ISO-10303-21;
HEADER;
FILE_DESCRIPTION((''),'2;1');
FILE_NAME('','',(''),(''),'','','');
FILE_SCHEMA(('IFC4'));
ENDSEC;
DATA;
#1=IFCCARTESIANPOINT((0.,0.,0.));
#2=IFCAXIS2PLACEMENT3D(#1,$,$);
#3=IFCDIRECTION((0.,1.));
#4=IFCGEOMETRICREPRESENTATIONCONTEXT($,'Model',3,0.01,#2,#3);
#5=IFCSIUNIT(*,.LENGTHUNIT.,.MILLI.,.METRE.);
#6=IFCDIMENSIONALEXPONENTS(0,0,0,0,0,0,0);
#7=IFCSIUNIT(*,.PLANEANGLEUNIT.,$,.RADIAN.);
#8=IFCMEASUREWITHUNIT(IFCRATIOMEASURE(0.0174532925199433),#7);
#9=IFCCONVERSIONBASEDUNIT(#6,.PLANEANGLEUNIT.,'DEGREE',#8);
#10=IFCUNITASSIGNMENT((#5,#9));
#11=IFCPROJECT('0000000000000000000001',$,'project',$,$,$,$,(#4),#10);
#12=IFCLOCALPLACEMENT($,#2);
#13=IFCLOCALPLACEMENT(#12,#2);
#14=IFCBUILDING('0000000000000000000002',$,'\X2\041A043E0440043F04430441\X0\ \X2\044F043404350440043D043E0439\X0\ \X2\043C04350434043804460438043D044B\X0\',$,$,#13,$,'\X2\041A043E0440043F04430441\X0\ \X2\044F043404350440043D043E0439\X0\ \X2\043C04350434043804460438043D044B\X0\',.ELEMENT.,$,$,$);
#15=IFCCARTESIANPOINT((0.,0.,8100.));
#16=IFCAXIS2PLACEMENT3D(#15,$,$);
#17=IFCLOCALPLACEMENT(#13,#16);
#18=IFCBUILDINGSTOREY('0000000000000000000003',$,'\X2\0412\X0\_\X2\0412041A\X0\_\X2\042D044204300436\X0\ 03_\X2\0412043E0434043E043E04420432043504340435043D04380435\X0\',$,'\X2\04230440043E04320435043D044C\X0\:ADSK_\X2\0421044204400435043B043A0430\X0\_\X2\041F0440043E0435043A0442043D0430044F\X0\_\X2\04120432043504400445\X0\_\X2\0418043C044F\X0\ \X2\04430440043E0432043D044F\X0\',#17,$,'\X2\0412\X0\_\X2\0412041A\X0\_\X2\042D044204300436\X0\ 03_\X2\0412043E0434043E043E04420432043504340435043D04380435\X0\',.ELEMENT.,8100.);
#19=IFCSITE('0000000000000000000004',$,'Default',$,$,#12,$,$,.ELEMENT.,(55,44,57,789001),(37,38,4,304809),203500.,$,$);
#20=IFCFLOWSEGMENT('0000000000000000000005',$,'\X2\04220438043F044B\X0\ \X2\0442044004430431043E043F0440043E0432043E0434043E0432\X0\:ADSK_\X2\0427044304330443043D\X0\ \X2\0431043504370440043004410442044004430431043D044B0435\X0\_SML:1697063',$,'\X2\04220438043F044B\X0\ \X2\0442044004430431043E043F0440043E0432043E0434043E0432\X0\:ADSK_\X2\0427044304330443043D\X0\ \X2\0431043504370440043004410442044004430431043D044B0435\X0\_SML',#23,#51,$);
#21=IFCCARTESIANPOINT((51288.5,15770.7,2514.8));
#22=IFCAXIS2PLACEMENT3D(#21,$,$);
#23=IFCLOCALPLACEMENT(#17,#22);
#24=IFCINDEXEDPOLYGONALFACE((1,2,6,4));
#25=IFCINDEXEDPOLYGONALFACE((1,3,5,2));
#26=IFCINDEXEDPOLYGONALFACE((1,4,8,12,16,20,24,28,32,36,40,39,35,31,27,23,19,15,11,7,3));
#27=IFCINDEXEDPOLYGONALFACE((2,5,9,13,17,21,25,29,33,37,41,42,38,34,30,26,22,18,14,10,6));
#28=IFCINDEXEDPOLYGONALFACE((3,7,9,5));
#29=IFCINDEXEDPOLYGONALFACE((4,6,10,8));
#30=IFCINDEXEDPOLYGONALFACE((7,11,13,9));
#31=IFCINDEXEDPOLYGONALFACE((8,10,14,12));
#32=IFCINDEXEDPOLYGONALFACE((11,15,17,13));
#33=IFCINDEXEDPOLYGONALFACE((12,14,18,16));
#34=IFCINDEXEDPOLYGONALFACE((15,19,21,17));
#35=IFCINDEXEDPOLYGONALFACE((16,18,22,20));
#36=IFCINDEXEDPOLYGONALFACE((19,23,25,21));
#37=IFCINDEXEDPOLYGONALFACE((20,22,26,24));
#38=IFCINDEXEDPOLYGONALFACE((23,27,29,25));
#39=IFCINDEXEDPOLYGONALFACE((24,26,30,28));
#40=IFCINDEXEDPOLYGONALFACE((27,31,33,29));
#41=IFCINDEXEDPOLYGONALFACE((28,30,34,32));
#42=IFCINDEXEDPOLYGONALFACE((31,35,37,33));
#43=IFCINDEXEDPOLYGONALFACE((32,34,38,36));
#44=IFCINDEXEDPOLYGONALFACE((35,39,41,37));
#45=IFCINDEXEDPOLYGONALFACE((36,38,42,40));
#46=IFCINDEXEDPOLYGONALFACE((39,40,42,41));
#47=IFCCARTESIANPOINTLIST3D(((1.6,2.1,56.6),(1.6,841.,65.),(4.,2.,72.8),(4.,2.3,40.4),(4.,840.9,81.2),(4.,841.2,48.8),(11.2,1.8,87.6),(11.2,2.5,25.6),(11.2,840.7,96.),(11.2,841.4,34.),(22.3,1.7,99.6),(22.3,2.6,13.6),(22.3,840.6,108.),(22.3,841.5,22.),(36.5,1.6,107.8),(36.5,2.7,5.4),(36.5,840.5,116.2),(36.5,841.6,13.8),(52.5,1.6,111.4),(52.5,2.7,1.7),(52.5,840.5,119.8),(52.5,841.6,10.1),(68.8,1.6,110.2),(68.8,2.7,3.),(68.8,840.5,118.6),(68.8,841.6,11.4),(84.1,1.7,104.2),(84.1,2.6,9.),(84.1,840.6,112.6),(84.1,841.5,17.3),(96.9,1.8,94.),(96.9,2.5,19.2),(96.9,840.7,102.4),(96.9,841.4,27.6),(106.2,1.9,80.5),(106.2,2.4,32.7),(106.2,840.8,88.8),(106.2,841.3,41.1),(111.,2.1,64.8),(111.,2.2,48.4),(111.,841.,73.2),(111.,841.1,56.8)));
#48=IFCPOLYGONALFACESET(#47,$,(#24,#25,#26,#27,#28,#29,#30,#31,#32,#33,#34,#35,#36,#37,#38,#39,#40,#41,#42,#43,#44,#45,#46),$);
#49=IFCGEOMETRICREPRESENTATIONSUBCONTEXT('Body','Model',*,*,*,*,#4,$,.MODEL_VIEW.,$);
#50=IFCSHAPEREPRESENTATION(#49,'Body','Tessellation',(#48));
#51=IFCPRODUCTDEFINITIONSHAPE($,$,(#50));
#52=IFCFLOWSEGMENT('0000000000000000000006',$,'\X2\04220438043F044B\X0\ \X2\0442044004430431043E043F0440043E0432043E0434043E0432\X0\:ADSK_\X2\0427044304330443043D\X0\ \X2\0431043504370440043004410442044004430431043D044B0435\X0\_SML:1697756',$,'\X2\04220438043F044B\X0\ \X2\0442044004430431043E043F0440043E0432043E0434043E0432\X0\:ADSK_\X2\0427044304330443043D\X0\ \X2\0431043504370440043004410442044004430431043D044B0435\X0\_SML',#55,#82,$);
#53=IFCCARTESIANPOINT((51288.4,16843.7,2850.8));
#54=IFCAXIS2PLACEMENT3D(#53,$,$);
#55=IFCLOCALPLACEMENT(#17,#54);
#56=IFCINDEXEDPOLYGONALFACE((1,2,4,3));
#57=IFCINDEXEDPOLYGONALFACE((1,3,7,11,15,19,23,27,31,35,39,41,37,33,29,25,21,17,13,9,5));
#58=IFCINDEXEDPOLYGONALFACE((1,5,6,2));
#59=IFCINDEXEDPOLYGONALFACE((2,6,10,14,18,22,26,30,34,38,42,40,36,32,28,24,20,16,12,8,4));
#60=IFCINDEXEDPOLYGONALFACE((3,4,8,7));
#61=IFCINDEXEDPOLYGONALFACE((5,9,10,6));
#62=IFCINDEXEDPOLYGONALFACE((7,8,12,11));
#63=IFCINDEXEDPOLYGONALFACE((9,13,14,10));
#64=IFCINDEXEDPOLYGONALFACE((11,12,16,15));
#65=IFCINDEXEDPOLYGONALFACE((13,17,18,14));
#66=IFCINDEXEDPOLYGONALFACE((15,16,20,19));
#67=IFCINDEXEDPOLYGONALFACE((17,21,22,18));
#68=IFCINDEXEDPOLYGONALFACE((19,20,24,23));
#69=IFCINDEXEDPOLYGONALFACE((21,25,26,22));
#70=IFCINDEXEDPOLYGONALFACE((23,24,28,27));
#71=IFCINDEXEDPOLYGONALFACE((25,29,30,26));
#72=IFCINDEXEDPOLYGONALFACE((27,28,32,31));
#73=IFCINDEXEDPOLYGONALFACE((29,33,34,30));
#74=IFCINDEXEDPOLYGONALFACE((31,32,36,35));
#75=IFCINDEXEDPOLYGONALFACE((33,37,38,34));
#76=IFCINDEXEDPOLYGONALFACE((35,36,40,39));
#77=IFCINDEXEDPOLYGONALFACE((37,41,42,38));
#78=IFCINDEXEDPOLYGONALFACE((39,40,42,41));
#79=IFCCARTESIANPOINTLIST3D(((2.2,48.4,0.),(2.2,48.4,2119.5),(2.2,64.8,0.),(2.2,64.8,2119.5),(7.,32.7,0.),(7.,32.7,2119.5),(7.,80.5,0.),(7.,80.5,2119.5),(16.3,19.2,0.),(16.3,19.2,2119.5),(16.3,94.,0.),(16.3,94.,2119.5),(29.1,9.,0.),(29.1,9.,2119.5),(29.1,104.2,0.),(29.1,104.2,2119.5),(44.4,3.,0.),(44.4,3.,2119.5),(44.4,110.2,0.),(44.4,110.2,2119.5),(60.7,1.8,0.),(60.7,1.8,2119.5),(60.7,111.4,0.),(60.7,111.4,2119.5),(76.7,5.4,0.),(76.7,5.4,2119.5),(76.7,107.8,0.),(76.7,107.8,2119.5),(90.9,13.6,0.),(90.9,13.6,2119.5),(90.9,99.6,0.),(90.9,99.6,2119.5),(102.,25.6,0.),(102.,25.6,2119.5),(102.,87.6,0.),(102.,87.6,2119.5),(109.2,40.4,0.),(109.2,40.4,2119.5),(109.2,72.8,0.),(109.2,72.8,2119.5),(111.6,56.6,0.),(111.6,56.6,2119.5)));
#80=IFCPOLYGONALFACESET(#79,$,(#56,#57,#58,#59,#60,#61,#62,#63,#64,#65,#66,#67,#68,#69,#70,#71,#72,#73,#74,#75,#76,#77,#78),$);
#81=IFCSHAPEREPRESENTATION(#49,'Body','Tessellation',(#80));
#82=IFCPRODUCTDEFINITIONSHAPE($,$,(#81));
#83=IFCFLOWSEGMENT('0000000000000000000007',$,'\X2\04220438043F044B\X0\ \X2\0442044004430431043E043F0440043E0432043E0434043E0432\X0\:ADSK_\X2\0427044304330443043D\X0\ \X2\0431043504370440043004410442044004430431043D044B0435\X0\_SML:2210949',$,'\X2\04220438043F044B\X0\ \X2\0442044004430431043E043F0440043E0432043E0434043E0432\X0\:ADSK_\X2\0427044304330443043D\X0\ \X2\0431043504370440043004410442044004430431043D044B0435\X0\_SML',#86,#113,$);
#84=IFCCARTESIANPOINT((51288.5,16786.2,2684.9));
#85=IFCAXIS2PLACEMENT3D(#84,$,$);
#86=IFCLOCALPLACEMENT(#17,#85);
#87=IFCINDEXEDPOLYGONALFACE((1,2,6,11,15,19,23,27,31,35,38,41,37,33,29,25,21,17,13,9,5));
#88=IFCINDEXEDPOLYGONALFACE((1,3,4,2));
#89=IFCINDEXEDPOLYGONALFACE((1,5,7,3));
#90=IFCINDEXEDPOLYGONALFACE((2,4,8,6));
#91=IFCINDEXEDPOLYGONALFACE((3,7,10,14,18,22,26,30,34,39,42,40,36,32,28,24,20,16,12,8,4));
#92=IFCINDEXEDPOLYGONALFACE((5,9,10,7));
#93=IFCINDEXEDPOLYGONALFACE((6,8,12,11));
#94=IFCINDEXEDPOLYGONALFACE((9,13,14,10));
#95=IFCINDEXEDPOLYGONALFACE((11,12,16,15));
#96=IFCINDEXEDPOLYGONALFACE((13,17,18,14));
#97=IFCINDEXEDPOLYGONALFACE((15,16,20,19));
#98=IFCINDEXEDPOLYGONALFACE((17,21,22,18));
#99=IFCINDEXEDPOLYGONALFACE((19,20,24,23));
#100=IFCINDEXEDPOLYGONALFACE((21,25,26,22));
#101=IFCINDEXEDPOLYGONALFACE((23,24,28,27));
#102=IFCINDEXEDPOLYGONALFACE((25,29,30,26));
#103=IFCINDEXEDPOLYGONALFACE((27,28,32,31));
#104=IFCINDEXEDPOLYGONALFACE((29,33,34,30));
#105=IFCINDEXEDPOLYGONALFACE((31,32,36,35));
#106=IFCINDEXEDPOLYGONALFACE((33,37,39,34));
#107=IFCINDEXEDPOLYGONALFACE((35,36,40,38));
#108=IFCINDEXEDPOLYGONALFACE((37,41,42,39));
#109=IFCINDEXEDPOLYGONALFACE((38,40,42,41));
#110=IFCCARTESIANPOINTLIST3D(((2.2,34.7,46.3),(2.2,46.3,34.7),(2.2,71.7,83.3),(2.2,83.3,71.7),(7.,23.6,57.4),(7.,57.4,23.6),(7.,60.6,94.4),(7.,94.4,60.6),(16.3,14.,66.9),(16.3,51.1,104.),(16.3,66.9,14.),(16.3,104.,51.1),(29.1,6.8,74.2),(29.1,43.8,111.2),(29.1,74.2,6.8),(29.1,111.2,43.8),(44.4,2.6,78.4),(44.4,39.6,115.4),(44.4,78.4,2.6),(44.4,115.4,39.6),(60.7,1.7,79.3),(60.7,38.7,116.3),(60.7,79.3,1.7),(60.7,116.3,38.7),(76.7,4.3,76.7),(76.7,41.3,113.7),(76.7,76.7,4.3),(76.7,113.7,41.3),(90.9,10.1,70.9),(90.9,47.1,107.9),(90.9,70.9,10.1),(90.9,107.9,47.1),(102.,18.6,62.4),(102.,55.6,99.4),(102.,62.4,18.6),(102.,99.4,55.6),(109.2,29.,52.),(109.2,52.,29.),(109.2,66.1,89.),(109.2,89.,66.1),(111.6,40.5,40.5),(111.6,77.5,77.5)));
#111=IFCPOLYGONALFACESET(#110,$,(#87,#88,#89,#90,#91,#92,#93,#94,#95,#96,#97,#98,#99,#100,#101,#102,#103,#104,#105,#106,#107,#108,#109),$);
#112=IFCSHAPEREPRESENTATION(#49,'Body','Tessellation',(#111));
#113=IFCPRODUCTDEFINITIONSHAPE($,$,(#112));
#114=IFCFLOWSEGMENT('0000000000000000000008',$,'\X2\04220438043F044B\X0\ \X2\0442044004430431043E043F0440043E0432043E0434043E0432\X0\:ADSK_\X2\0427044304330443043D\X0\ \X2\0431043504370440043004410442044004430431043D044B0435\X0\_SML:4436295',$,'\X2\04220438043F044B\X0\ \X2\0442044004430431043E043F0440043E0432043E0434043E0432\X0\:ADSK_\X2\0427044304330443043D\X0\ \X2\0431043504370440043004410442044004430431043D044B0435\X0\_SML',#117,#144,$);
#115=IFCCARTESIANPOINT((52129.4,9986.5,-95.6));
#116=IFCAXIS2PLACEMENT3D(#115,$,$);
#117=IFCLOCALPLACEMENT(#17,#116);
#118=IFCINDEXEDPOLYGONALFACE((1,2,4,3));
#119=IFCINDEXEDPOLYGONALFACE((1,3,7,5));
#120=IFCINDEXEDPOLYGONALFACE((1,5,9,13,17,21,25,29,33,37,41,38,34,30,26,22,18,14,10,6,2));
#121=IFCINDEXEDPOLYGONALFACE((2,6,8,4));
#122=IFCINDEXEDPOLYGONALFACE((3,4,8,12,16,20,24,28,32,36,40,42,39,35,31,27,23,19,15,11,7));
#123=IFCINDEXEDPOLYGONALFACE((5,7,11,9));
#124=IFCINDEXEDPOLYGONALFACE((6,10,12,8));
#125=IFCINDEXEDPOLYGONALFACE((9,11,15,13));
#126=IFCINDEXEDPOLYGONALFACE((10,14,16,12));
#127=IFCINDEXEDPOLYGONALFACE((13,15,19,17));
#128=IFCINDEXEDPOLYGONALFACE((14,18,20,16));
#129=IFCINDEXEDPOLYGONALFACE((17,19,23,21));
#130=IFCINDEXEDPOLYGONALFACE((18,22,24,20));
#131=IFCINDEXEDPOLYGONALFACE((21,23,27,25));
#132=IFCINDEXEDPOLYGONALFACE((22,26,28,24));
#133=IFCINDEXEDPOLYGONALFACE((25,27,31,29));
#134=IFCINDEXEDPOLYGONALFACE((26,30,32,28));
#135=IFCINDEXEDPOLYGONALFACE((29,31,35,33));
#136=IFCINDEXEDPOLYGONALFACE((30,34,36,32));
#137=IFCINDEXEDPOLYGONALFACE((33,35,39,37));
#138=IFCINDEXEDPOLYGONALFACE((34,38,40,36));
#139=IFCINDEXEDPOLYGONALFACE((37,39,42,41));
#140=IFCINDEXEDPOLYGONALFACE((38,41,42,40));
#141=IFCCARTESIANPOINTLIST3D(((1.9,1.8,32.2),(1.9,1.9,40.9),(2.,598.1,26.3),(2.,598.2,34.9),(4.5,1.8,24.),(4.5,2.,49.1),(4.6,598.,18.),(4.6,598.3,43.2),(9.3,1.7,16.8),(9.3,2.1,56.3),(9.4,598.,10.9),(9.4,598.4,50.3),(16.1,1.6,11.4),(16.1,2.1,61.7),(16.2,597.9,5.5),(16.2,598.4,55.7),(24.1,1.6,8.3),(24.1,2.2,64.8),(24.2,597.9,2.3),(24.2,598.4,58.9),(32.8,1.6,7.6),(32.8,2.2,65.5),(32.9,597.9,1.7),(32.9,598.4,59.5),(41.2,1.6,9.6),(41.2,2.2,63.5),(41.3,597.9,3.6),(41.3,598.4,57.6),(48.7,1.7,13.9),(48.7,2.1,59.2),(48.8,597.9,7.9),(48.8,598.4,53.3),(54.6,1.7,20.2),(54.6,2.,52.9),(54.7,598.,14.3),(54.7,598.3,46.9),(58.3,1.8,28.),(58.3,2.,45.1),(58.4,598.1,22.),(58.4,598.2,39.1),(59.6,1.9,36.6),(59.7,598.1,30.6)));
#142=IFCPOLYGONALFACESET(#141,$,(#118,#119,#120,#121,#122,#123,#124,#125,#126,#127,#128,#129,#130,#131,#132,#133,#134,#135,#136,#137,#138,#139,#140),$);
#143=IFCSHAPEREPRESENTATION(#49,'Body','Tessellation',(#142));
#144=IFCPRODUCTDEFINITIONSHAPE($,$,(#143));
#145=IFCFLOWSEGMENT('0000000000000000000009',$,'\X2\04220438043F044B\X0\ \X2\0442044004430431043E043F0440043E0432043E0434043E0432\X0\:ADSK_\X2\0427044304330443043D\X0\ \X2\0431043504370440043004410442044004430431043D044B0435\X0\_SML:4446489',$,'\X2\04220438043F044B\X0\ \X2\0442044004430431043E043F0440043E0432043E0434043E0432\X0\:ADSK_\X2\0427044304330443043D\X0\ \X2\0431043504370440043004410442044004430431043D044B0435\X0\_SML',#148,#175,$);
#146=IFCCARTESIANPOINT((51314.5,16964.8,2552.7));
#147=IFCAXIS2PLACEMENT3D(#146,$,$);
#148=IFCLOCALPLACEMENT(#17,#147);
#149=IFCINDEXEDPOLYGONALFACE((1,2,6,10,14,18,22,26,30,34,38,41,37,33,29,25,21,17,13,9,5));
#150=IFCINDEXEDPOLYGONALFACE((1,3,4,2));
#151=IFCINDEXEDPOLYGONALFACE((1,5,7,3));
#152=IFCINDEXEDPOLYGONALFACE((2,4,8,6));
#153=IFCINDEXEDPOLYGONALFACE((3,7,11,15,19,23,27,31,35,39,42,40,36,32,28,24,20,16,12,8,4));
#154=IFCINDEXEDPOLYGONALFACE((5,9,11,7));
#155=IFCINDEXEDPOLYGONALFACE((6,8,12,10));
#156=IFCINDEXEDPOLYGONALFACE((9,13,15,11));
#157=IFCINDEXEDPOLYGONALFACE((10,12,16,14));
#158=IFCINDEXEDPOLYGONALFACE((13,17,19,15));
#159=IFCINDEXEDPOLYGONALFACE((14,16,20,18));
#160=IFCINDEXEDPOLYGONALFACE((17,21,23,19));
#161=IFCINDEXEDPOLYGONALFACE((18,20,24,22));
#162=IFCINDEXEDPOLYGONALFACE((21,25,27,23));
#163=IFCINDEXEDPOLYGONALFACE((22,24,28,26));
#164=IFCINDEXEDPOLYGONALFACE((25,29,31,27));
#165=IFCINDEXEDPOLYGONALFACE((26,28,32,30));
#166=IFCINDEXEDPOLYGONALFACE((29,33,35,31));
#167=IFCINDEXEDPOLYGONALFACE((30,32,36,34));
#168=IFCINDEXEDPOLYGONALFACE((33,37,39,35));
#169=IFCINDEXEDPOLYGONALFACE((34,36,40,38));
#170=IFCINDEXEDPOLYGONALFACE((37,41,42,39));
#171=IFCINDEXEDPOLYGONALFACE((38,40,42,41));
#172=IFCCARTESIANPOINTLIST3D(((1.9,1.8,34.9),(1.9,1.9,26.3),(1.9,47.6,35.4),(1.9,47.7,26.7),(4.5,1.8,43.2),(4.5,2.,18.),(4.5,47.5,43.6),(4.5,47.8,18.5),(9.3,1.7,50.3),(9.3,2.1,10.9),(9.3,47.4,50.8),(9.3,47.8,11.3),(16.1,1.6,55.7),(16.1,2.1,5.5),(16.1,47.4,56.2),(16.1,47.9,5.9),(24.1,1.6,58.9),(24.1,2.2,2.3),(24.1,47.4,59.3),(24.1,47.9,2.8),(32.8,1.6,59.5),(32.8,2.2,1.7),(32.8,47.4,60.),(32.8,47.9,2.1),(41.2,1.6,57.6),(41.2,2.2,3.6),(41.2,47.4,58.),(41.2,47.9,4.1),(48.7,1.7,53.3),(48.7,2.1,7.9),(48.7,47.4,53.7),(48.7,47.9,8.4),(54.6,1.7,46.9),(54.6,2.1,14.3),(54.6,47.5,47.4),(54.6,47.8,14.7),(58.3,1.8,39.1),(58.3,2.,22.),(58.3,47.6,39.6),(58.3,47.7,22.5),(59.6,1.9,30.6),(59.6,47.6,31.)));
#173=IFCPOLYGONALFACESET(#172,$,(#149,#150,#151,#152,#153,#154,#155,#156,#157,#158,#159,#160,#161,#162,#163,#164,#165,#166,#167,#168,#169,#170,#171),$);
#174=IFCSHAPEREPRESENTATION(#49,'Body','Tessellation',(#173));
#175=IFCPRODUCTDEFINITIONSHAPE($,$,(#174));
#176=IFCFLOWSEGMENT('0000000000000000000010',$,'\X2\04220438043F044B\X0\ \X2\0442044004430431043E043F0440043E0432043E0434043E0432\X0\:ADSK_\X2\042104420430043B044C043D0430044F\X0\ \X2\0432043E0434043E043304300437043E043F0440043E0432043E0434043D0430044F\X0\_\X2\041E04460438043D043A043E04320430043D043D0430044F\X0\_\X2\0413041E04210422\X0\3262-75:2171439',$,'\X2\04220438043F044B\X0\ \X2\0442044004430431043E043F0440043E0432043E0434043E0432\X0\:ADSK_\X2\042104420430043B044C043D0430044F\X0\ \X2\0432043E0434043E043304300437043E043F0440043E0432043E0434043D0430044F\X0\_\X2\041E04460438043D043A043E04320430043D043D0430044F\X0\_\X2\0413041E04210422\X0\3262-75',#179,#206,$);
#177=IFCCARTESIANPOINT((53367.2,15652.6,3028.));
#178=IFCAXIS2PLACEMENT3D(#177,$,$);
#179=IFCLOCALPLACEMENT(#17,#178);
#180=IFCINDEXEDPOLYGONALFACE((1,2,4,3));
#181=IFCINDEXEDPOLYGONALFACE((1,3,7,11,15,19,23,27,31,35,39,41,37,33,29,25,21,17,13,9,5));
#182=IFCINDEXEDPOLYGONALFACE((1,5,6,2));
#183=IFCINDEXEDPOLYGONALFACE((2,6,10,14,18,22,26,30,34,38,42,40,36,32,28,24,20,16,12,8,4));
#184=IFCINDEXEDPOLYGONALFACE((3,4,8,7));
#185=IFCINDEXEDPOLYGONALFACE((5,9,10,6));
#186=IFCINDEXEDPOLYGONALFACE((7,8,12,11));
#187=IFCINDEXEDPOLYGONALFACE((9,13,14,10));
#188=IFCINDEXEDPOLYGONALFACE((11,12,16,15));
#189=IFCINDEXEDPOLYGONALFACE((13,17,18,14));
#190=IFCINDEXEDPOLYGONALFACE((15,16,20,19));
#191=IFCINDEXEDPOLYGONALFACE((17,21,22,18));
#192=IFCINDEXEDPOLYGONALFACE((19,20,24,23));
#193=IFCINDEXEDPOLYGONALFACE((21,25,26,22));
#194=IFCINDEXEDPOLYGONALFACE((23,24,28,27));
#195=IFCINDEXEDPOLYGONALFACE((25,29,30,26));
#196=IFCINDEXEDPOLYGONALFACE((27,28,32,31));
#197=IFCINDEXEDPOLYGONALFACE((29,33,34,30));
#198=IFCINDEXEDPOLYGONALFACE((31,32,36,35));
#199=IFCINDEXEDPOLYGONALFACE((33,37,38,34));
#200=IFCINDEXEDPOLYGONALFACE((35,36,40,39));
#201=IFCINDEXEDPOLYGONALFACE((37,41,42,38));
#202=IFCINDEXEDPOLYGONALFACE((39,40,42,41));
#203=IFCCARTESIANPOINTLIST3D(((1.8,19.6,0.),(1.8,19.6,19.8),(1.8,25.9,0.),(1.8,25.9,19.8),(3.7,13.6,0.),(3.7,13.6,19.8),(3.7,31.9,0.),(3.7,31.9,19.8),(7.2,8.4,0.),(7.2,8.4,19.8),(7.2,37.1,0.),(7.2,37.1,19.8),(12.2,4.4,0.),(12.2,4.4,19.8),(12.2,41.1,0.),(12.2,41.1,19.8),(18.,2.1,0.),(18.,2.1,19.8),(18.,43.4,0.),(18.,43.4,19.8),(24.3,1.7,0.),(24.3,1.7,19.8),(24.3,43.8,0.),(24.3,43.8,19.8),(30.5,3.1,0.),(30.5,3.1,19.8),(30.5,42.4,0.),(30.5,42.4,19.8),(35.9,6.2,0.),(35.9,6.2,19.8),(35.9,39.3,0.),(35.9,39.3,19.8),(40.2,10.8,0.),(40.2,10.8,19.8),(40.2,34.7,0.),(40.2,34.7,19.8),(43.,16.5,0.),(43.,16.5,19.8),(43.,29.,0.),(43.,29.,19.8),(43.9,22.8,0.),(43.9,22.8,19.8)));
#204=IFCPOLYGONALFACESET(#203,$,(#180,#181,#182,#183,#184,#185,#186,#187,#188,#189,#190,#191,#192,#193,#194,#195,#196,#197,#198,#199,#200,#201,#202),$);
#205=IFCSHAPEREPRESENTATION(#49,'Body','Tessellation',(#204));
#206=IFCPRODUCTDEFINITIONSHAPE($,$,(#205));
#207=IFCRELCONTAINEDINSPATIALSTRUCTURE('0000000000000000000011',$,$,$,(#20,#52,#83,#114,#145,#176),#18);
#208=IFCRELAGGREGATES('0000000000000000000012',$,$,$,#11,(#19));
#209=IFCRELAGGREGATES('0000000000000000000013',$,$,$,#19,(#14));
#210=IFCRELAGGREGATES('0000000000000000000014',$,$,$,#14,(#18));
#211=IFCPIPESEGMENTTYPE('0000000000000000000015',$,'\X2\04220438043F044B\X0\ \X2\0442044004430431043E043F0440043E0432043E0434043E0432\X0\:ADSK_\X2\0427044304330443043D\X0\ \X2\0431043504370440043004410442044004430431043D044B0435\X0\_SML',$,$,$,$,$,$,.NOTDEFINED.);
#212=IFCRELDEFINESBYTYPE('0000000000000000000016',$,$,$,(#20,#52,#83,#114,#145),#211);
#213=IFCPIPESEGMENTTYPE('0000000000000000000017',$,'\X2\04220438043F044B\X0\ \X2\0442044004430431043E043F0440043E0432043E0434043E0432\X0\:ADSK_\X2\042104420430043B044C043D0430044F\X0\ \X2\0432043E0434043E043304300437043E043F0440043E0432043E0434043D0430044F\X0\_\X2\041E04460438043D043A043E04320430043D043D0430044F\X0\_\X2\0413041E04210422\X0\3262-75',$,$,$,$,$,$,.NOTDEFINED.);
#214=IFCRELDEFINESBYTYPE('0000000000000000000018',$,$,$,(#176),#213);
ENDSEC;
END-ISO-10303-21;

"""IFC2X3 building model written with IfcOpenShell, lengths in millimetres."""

from ifc_helpers import new_model, entity, si_unit, converted_unit, direction, frame, origin, origin_2d_with_axis, place, context, subcontext, project, spatial, circle, extrude, type_object, element, save


model = new_model("IFC2X3")

# Units and contexts
model_context = context("Model", 3, precision=0.01, world=origin(), true_north=direction((0.0, 1.0)))
body_context = subcontext(model_context, "Body", "Model", "MODEL_VIEW")
ifc_project = project(units=[si_unit("LENGTHUNIT", "METRE", prefix="MILLI"), converted_unit("PLANEANGLEUNIT", "DEGREE", entity("IfcRatioMeasure", 0.0174532925199433), si_unit("PLANEANGLEUNIT", "RADIAN"), dimensions=[0, 0, 0, 0, 0, 0, 0])], contexts=[model_context])

# Site, building, storey
site_placement = place(None, origin())
site = spatial("IfcSite", under=ifc_project, at=site_placement, Name="Default", CompositionType="ELEMENT", RefLatitude=(55, 44, 57, 789001), RefLongitude=(37, 38, 4, 304809), RefElevation=203500.0)
building_placement = place(site_placement, origin())
building = spatial("IfcBuilding", under=site, at=building_placement, Name="Корпус ядерной медицины", LongName="Корпус ядерной медицины", CompositionType="ELEMENT")
storey_placement = place(building_placement, frame((0.0, 0.0, 8100.0)))
storey = spatial("IfcBuildingStorey", under=building, at=storey_placement, Name="В_ВК_Этаж 03_Водоотведение", ObjectType="Уровень:ADSK_Стрелка_Проектная_Вверх_Имя уровня", LongName="В_ВК_Этаж 03_Водоотведение", CompositionType="ELEMENT", Elevation=8100.0)

# Flow segments
pipe_segment_type_1 = type_object("IfcPipeSegmentType", Name="Типы трубопроводов:ADSK_Чугун безраструбные_SML", PredefinedType="NOTDEFINED")
flow_segment_1_placement = place(storey_placement, frame((51288.5, 15770.7, 2514.8)))
element("IfcFlowSegment", 1, at=flow_segment_1_placement, inside=storey, type_object=pipe_segment_type_1, Name="Типы трубопроводов:ADSK_Чугун безраструбные_SML:1697063", ObjectType="Типы трубопроводов:ADSK_Чугун безраструбные_SML", context=body_context, shape_type="SweptSolid", body=[
    extrude(circle(Radius=55.0, at=origin_2d_with_axis()), frame((56.6, 2.1, 56.6), z_axis=(0.0, 0.99995, 0.01), x_axis=(-1.0, 0.0, 0.0)), (0.0, 0.0, 1.0), 838.9),
])
flow_segment_2_placement = place(storey_placement, frame((51288.4, 16843.7, 2850.8)))
element("IfcFlowSegment", 2, at=flow_segment_2_placement, inside=storey, type_object=pipe_segment_type_1, Name="Типы трубопроводов:ADSK_Чугун безраструбные_SML:1697756", ObjectType="Типы трубопроводов:ADSK_Чугун безраструбные_SML", context=body_context, shape_type="SweptSolid", body=[
    extrude(circle(Radius=55.0, at=origin_2d_with_axis()), frame((56.6, 56.6, 0.0)), (0.0, 0.0, 1.0), 2119.5),
])
flow_segment_3_placement = place(storey_placement, frame((51288.5, 16786.2, 2684.9)))
element("IfcFlowSegment", 3, at=flow_segment_3_placement, inside=storey, type_object=pipe_segment_type_1, Name="Типы трубопроводов:ADSK_Чугун безраструбные_SML:2210949", ObjectType="Типы трубопроводов:ADSK_Чугун безраструбные_SML", context=body_context, shape_type="SweptSolid", body=[
    extrude(circle(Radius=55.0, at=origin_2d_with_axis()), frame((56.6, 40.5, 40.5), z_axis=(0.0, 0.707107, 0.707107), x_axis=(1.0, 0.0, 0.0)), (0.0, 0.0, 1.0), 52.4),
])
flow_segment_4_placement = place(storey_placement, frame((52129.4, 9986.5, -95.6)))
element("IfcFlowSegment", 4, at=flow_segment_4_placement, inside=storey, type_object=pipe_segment_type_1, Name="Типы трубопроводов:ADSK_Чугун безраструбные_SML:4436295", ObjectType="Типы трубопроводов:ADSK_Чугун безраструбные_SML", context=body_context, shape_type="SweptSolid", body=[
    extrude(circle(Radius=29.0, at=origin_2d_with_axis()), frame((30.7, 598.1, 30.6), z_axis=(-0.000176, -0.99995, 0.009999), x_axis=(1.0, -0.000176, 0.0)), (0.0, 0.0, 1.0), 596.3),
])
flow_segment_5_placement = place(storey_placement, frame((51314.5, 16964.8, 2552.7)))
element("IfcFlowSegment", 5, at=flow_segment_5_placement, inside=storey, type_object=pipe_segment_type_1, Name="Типы трубопроводов:ADSK_Чугун безраструбные_SML:4446489", ObjectType="Типы трубопроводов:ADSK_Чугун безраструбные_SML", context=body_context, shape_type="SweptSolid", body=[
    extrude(circle(Radius=29.0, at=origin_2d_with_axis()), frame((30.6, 1.9, 30.6), z_axis=(0.0, 0.99995, 0.01), x_axis=(1.0, 0.0, 0.0)), (0.0, 0.0, 1.0), 45.8),
])
pipe_segment_type_2 = type_object("IfcPipeSegmentType", Name="Типы трубопроводов:ADSK_Стальная водогазопроводная_Оцинкованная_ГОСТ3262-75", PredefinedType="NOTDEFINED")
flow_segment_6_placement = place(storey_placement, frame((53367.2, 15652.6, 3028.0)))
element("IfcFlowSegment", 6, at=flow_segment_6_placement, inside=storey, type_object=pipe_segment_type_2, Name="Типы трубопроводов:ADSK_Стальная водогазопроводная_Оцинкованная_ГОСТ3262-75:2171439", ObjectType="Типы трубопроводов:ADSK_Стальная водогазопроводная_Оцинкованная_ГОСТ3262-75", context=body_context, shape_type="SweptSolid", body=[
    extrude(circle(Radius=21.1, at=origin_2d_with_axis()), frame((22.8, 22.8, 0.0)), (0.0, 0.0, 1.0), 19.8),
])

save(model, "model.ifc")
